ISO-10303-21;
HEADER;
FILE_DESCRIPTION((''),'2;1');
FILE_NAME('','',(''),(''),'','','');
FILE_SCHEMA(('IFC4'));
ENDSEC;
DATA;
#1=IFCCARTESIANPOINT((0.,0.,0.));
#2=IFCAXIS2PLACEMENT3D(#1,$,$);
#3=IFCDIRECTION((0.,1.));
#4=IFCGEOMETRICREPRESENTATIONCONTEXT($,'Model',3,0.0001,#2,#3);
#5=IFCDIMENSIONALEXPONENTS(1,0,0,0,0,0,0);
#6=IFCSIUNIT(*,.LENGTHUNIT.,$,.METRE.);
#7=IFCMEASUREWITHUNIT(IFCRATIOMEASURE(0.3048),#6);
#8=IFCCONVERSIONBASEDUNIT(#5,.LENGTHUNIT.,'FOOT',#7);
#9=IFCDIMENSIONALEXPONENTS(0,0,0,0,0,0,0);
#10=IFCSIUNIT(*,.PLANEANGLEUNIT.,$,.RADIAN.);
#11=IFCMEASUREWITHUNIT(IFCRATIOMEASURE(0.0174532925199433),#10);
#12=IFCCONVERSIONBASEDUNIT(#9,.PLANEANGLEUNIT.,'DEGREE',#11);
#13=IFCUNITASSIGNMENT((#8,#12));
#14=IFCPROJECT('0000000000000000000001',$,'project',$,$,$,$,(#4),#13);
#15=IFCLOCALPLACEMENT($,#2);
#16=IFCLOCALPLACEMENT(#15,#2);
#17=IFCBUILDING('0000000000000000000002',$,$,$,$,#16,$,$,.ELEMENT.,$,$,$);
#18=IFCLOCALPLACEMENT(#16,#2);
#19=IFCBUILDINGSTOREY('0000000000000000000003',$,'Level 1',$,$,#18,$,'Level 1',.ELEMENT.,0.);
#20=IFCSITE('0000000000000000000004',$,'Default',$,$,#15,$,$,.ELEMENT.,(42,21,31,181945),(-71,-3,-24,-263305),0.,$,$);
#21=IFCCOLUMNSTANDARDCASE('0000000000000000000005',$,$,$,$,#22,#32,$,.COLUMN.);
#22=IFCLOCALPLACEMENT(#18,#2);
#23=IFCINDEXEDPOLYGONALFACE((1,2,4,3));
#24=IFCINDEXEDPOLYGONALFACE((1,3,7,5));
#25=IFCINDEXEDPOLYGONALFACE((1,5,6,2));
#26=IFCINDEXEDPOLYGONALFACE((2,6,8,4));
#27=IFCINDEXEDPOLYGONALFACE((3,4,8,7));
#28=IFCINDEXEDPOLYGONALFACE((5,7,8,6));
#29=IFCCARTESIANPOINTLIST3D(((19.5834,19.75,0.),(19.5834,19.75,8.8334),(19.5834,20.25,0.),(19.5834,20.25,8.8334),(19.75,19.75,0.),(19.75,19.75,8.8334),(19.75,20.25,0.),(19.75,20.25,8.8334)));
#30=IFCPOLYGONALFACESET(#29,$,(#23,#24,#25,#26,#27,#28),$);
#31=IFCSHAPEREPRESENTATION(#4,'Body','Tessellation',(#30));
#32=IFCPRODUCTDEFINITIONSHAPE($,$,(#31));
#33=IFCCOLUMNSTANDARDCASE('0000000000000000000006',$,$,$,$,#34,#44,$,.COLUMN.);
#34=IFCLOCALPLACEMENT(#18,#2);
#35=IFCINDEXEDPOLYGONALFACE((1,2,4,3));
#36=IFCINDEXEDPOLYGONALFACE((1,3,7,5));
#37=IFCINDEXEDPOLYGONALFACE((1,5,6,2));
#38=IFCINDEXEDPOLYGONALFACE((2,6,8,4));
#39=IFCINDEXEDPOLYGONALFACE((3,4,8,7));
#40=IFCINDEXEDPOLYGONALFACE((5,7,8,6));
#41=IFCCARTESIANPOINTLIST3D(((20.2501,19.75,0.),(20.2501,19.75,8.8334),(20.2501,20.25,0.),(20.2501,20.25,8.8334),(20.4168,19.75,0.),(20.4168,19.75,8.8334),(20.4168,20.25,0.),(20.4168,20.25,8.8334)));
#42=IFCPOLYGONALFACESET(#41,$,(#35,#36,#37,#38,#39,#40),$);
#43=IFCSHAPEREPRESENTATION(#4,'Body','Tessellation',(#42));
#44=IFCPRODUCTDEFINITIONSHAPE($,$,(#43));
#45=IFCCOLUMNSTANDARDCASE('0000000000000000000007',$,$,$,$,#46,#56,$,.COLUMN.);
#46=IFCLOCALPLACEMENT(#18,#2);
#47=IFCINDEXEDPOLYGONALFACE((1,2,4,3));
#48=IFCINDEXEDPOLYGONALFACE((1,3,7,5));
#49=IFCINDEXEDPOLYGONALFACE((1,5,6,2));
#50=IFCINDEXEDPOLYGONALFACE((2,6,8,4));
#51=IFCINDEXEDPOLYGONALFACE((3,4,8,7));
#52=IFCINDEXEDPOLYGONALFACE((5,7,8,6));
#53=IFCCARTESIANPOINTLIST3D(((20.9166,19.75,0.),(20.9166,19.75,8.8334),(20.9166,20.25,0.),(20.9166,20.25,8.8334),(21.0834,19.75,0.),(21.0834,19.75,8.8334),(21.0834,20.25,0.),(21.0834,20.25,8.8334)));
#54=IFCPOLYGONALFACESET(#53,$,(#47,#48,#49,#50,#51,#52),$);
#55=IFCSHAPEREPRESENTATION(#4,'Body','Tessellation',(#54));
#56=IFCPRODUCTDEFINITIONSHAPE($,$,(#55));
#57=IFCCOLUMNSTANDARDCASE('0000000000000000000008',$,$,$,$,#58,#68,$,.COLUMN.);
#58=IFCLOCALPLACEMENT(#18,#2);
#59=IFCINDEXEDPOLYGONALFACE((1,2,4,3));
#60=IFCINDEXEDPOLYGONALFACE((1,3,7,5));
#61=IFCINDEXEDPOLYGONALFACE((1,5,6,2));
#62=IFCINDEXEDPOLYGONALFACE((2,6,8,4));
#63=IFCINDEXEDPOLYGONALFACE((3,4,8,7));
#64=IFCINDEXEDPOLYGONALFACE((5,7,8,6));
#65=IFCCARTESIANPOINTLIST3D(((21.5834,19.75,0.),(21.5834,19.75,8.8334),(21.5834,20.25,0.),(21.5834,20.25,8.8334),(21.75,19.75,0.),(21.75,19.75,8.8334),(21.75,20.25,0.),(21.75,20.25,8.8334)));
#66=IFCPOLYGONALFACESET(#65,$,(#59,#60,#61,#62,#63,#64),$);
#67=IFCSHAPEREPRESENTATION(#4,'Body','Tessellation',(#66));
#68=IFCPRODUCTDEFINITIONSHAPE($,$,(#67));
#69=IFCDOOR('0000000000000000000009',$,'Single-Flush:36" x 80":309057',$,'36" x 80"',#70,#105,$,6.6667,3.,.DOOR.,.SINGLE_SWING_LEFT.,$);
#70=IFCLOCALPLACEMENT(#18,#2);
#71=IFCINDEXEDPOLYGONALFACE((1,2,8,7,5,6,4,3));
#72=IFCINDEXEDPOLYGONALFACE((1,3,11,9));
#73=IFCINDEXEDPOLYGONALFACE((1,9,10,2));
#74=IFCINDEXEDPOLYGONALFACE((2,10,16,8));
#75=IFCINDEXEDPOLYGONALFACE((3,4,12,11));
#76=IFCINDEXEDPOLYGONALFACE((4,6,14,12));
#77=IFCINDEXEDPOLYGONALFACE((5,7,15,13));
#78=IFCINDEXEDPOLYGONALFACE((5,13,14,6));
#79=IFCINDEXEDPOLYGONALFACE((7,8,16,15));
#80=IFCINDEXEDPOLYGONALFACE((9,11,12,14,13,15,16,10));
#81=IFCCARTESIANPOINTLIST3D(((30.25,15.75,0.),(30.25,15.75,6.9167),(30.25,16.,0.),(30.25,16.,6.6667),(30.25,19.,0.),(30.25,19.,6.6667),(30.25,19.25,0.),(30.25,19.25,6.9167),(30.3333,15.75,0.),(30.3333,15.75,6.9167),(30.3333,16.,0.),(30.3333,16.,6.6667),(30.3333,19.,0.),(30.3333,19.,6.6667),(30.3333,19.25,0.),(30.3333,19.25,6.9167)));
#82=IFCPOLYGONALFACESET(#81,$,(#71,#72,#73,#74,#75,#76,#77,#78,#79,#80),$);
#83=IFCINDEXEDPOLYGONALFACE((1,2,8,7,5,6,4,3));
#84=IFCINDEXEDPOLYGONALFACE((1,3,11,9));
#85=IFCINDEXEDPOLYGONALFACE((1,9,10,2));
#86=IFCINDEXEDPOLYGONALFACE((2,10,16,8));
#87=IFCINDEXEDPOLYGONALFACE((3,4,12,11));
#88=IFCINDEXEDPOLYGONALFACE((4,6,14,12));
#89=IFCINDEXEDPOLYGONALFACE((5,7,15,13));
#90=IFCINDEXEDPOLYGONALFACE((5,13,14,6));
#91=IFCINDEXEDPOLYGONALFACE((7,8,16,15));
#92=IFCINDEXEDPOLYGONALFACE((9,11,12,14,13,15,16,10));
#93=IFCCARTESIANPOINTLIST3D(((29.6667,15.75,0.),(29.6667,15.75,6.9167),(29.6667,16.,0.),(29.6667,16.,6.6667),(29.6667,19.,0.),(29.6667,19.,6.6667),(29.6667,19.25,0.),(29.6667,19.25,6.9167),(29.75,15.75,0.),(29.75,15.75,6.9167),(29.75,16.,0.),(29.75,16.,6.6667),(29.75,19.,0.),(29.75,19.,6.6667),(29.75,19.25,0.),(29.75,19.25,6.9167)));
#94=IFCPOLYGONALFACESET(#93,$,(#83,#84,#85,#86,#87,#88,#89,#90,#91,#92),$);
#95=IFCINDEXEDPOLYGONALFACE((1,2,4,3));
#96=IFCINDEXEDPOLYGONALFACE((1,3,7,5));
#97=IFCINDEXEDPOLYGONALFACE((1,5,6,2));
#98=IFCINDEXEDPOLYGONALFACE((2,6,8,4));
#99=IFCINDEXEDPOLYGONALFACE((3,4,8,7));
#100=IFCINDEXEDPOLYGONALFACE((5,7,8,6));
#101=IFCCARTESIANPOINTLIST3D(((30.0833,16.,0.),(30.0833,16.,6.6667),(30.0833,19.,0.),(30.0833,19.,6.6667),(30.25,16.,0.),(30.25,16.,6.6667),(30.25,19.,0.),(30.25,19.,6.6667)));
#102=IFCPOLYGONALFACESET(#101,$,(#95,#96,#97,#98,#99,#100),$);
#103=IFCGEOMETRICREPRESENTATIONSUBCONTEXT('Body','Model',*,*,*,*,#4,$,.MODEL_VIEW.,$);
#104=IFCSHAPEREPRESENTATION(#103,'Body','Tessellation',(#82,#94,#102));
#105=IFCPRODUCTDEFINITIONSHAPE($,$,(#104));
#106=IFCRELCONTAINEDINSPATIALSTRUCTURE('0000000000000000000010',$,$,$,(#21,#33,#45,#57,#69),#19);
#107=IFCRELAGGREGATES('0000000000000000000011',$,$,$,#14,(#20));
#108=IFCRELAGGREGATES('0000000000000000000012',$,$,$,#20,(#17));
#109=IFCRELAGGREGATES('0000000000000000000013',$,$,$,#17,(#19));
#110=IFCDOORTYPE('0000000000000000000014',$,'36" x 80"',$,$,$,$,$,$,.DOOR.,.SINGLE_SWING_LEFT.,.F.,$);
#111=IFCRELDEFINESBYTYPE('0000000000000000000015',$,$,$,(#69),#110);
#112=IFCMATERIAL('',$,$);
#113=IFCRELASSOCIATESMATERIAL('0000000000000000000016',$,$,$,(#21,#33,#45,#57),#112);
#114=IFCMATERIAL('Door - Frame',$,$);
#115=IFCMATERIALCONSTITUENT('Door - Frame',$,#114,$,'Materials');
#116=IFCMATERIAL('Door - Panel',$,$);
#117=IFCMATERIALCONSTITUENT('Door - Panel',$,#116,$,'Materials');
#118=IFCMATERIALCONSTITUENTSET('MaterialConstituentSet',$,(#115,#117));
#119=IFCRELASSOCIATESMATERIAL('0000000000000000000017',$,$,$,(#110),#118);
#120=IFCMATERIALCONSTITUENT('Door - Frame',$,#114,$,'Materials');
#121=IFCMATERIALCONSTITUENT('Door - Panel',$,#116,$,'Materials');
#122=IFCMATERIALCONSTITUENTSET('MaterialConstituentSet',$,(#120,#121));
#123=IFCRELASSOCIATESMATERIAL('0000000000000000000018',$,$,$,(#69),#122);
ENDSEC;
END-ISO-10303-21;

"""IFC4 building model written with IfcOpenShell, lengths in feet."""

from ifc_helpers import new_model, entity, si_unit, converted_unit, direction, frame, origin, origin_2d_with_axis, place, context, subcontext, project, spatial, polyline, rectangle, outline, extrude, source, transform, mapped, material, constituent, constituent_set, type_object, type_shapes, element, save


model = new_model("IFC4")

# Units and contexts
model_context = context("Model", 3, precision=0.0001, world=origin(), true_north=direction((0.0, 1.0)))
body_context = subcontext(model_context, "Body", "Model", "MODEL_VIEW")
ifc_project = project(units=[converted_unit("LENGTHUNIT", "FOOT", entity("IfcRatioMeasure", 0.3048), si_unit("LENGTHUNIT", "METRE"), dimensions=[1, 0, 0, 0, 0, 0, 0]), converted_unit("PLANEANGLEUNIT", "DEGREE", entity("IfcRatioMeasure", 0.0174532925199433), si_unit("PLANEANGLEUNIT", "RADIAN"), dimensions=[0, 0, 0, 0, 0, 0, 0])], contexts=[model_context])

# Site, building, storey
site_placement = place(None, origin())
site = spatial("IfcSite", under=ifc_project, at=site_placement, Name="Default", CompositionType="ELEMENT", RefLatitude=(42, 21, 31, 181945), RefLongitude=(-71, -3, -24, -263305), RefElevation=0.0)
building_placement = place(site_placement, origin())
building = spatial("IfcBuilding", under=site, at=building_placement, CompositionType="ELEMENT")
storey_placement = place(building_placement, origin())
storey = spatial("IfcBuildingStorey", under=building, at=storey_placement, Name="Level 1", LongName="Level 1", CompositionType="ELEMENT", Elevation=0.0)

# Columns
ifc_material_1 = material(Name="")
placement_1 = place(storey_placement, frame((0.25, 20.0, 0.0)))
for number, where, z_axis, x_axis in (
    (1, (19.4167, 0.0, 0.0), (0.0, 0.0, 1.0), (1.0, 0.0, 0.0)),
    (2, (20.0834, 0.0, 0.0), (0.0, 0.0, 1.0), (1.0, 0.0, 0.0)),
    (3, (20.75, 0.0, 0.0), (0.0, 0.0, 1.0), (1.0, 0.0, 0.0)),
    (4, (21.4167, 0.0, 0.0), (0.0, 0.0, 1.0), (1.0, 0.0, 0.0)),
):
    element("IfcColumnStandardCase", number, at=place(placement_1, frame(where, z_axis=z_axis, x_axis=x_axis)), inside=storey, material=ifc_material_1, PredefinedType="COLUMN", context=model_context, shape_type="SweptSolid", body=[
        extrude(rectangle(XDim=0.1667, YDim=0.5), origin(), (0.0, 0.0, 1.0), 8.8334),
    ])
placement_2 = place(storey_placement, frame((30.0, 45.75, 0.0), z_axis=(0.0, 0.0, 1.0), x_axis=(0.0, -1.0, 0.0)))

# Door
ifc_material_2 = material(Name="Door - Frame")
ifc_constituent_1 = constituent(ifc_material_2, Name="Door - Frame", Category="Materials")
ifc_material_3 = material(Name="Door - Panel")
ifc_constituent_2 = constituent(ifc_material_3, Name="Door - Panel", Category="Materials")
ifc_constituent_set_1 = constituent_set(constituents=[ifc_constituent_1, ifc_constituent_2], Name="MaterialConstituentSet")
ifc_constituent_3 = constituent(ifc_material_2, Name="Door - Frame", Category="Materials")
ifc_constituent_4 = constituent(ifc_material_3, Name="Door - Panel", Category="Materials")
ifc_constituent_set_2 = constituent_set(constituents=[ifc_constituent_3, ifc_constituent_4], Name="MaterialConstituentSet")
door_type = type_object("IfcDoorType", Name="36\" x 80\"", OperationType="SINGLE_SWING_LEFT", ParameterTakesPrecedence=False, PredefinedType="DOOR", material=ifc_constituent_set_2)
shared_shape = source(origin(), body_context, "Body", "SweptSolid", [
    extrude(outline(polyline([(-1.75, -3.5208), (1.75, -3.5208), (1.75, 3.3958), (1.5, 3.3958), (1.5, -3.2708), (-1.5, -3.2708), (-1.5, 3.3958), (-1.75, 3.3958), (-1.75, -3.5208)])), frame((1.5, 0.5833, 3.3958), z_axis=(0.0, -1.0, 0.0), x_axis=(-1.0, 0.0, 0.0)), (0.0, 0.0, 1.0), 0.0833),
    extrude(outline(polyline([(-3.5208, -1.75), (3.3958, -1.75), (3.3958, -1.5), (-3.2708, -1.5), (-3.2708, 1.5), (3.3958, 1.5), (3.3958, 1.75), (-3.5208, 1.75), (-3.5208, -1.75)])), frame((1.5, 0.0, 3.3958), z_axis=(0.0, -1.0, 0.0), x_axis=(0.0, 0.0, -1.0)), (0.0, 0.0, 1.0), 0.0833),
    extrude(rectangle(XDim=3.0, YDim=0.1667, at=origin_2d_with_axis()), frame((1.5, 0.4167, 0.0)), (0.0, 0.0, 1.0), 6.6667),
])
type_shapes(door_type, [shared_shape])
placement_3 = place(placement_2, frame((26.75, -0.25, 0.0)))
door_placement = place(placement_3, origin())
element("IfcDoor", 5, at=door_placement, inside=storey, type_object=door_type, material=ifc_constituent_set_1, Name="Single-Flush:36\" x 80\":309057", ObjectType="36\" x 80\"", OperationType="SINGLE_SWING_LEFT", OverallHeight=6.6667, OverallWidth=3.0, PredefinedType="DOOR", context=body_context, shape_type="MappedRepresentation", body=[
    mapped(shared_shape, transform((0.0, 0.0, 0.0), scale=1.0)),
])

save(model, "model.ifc")
